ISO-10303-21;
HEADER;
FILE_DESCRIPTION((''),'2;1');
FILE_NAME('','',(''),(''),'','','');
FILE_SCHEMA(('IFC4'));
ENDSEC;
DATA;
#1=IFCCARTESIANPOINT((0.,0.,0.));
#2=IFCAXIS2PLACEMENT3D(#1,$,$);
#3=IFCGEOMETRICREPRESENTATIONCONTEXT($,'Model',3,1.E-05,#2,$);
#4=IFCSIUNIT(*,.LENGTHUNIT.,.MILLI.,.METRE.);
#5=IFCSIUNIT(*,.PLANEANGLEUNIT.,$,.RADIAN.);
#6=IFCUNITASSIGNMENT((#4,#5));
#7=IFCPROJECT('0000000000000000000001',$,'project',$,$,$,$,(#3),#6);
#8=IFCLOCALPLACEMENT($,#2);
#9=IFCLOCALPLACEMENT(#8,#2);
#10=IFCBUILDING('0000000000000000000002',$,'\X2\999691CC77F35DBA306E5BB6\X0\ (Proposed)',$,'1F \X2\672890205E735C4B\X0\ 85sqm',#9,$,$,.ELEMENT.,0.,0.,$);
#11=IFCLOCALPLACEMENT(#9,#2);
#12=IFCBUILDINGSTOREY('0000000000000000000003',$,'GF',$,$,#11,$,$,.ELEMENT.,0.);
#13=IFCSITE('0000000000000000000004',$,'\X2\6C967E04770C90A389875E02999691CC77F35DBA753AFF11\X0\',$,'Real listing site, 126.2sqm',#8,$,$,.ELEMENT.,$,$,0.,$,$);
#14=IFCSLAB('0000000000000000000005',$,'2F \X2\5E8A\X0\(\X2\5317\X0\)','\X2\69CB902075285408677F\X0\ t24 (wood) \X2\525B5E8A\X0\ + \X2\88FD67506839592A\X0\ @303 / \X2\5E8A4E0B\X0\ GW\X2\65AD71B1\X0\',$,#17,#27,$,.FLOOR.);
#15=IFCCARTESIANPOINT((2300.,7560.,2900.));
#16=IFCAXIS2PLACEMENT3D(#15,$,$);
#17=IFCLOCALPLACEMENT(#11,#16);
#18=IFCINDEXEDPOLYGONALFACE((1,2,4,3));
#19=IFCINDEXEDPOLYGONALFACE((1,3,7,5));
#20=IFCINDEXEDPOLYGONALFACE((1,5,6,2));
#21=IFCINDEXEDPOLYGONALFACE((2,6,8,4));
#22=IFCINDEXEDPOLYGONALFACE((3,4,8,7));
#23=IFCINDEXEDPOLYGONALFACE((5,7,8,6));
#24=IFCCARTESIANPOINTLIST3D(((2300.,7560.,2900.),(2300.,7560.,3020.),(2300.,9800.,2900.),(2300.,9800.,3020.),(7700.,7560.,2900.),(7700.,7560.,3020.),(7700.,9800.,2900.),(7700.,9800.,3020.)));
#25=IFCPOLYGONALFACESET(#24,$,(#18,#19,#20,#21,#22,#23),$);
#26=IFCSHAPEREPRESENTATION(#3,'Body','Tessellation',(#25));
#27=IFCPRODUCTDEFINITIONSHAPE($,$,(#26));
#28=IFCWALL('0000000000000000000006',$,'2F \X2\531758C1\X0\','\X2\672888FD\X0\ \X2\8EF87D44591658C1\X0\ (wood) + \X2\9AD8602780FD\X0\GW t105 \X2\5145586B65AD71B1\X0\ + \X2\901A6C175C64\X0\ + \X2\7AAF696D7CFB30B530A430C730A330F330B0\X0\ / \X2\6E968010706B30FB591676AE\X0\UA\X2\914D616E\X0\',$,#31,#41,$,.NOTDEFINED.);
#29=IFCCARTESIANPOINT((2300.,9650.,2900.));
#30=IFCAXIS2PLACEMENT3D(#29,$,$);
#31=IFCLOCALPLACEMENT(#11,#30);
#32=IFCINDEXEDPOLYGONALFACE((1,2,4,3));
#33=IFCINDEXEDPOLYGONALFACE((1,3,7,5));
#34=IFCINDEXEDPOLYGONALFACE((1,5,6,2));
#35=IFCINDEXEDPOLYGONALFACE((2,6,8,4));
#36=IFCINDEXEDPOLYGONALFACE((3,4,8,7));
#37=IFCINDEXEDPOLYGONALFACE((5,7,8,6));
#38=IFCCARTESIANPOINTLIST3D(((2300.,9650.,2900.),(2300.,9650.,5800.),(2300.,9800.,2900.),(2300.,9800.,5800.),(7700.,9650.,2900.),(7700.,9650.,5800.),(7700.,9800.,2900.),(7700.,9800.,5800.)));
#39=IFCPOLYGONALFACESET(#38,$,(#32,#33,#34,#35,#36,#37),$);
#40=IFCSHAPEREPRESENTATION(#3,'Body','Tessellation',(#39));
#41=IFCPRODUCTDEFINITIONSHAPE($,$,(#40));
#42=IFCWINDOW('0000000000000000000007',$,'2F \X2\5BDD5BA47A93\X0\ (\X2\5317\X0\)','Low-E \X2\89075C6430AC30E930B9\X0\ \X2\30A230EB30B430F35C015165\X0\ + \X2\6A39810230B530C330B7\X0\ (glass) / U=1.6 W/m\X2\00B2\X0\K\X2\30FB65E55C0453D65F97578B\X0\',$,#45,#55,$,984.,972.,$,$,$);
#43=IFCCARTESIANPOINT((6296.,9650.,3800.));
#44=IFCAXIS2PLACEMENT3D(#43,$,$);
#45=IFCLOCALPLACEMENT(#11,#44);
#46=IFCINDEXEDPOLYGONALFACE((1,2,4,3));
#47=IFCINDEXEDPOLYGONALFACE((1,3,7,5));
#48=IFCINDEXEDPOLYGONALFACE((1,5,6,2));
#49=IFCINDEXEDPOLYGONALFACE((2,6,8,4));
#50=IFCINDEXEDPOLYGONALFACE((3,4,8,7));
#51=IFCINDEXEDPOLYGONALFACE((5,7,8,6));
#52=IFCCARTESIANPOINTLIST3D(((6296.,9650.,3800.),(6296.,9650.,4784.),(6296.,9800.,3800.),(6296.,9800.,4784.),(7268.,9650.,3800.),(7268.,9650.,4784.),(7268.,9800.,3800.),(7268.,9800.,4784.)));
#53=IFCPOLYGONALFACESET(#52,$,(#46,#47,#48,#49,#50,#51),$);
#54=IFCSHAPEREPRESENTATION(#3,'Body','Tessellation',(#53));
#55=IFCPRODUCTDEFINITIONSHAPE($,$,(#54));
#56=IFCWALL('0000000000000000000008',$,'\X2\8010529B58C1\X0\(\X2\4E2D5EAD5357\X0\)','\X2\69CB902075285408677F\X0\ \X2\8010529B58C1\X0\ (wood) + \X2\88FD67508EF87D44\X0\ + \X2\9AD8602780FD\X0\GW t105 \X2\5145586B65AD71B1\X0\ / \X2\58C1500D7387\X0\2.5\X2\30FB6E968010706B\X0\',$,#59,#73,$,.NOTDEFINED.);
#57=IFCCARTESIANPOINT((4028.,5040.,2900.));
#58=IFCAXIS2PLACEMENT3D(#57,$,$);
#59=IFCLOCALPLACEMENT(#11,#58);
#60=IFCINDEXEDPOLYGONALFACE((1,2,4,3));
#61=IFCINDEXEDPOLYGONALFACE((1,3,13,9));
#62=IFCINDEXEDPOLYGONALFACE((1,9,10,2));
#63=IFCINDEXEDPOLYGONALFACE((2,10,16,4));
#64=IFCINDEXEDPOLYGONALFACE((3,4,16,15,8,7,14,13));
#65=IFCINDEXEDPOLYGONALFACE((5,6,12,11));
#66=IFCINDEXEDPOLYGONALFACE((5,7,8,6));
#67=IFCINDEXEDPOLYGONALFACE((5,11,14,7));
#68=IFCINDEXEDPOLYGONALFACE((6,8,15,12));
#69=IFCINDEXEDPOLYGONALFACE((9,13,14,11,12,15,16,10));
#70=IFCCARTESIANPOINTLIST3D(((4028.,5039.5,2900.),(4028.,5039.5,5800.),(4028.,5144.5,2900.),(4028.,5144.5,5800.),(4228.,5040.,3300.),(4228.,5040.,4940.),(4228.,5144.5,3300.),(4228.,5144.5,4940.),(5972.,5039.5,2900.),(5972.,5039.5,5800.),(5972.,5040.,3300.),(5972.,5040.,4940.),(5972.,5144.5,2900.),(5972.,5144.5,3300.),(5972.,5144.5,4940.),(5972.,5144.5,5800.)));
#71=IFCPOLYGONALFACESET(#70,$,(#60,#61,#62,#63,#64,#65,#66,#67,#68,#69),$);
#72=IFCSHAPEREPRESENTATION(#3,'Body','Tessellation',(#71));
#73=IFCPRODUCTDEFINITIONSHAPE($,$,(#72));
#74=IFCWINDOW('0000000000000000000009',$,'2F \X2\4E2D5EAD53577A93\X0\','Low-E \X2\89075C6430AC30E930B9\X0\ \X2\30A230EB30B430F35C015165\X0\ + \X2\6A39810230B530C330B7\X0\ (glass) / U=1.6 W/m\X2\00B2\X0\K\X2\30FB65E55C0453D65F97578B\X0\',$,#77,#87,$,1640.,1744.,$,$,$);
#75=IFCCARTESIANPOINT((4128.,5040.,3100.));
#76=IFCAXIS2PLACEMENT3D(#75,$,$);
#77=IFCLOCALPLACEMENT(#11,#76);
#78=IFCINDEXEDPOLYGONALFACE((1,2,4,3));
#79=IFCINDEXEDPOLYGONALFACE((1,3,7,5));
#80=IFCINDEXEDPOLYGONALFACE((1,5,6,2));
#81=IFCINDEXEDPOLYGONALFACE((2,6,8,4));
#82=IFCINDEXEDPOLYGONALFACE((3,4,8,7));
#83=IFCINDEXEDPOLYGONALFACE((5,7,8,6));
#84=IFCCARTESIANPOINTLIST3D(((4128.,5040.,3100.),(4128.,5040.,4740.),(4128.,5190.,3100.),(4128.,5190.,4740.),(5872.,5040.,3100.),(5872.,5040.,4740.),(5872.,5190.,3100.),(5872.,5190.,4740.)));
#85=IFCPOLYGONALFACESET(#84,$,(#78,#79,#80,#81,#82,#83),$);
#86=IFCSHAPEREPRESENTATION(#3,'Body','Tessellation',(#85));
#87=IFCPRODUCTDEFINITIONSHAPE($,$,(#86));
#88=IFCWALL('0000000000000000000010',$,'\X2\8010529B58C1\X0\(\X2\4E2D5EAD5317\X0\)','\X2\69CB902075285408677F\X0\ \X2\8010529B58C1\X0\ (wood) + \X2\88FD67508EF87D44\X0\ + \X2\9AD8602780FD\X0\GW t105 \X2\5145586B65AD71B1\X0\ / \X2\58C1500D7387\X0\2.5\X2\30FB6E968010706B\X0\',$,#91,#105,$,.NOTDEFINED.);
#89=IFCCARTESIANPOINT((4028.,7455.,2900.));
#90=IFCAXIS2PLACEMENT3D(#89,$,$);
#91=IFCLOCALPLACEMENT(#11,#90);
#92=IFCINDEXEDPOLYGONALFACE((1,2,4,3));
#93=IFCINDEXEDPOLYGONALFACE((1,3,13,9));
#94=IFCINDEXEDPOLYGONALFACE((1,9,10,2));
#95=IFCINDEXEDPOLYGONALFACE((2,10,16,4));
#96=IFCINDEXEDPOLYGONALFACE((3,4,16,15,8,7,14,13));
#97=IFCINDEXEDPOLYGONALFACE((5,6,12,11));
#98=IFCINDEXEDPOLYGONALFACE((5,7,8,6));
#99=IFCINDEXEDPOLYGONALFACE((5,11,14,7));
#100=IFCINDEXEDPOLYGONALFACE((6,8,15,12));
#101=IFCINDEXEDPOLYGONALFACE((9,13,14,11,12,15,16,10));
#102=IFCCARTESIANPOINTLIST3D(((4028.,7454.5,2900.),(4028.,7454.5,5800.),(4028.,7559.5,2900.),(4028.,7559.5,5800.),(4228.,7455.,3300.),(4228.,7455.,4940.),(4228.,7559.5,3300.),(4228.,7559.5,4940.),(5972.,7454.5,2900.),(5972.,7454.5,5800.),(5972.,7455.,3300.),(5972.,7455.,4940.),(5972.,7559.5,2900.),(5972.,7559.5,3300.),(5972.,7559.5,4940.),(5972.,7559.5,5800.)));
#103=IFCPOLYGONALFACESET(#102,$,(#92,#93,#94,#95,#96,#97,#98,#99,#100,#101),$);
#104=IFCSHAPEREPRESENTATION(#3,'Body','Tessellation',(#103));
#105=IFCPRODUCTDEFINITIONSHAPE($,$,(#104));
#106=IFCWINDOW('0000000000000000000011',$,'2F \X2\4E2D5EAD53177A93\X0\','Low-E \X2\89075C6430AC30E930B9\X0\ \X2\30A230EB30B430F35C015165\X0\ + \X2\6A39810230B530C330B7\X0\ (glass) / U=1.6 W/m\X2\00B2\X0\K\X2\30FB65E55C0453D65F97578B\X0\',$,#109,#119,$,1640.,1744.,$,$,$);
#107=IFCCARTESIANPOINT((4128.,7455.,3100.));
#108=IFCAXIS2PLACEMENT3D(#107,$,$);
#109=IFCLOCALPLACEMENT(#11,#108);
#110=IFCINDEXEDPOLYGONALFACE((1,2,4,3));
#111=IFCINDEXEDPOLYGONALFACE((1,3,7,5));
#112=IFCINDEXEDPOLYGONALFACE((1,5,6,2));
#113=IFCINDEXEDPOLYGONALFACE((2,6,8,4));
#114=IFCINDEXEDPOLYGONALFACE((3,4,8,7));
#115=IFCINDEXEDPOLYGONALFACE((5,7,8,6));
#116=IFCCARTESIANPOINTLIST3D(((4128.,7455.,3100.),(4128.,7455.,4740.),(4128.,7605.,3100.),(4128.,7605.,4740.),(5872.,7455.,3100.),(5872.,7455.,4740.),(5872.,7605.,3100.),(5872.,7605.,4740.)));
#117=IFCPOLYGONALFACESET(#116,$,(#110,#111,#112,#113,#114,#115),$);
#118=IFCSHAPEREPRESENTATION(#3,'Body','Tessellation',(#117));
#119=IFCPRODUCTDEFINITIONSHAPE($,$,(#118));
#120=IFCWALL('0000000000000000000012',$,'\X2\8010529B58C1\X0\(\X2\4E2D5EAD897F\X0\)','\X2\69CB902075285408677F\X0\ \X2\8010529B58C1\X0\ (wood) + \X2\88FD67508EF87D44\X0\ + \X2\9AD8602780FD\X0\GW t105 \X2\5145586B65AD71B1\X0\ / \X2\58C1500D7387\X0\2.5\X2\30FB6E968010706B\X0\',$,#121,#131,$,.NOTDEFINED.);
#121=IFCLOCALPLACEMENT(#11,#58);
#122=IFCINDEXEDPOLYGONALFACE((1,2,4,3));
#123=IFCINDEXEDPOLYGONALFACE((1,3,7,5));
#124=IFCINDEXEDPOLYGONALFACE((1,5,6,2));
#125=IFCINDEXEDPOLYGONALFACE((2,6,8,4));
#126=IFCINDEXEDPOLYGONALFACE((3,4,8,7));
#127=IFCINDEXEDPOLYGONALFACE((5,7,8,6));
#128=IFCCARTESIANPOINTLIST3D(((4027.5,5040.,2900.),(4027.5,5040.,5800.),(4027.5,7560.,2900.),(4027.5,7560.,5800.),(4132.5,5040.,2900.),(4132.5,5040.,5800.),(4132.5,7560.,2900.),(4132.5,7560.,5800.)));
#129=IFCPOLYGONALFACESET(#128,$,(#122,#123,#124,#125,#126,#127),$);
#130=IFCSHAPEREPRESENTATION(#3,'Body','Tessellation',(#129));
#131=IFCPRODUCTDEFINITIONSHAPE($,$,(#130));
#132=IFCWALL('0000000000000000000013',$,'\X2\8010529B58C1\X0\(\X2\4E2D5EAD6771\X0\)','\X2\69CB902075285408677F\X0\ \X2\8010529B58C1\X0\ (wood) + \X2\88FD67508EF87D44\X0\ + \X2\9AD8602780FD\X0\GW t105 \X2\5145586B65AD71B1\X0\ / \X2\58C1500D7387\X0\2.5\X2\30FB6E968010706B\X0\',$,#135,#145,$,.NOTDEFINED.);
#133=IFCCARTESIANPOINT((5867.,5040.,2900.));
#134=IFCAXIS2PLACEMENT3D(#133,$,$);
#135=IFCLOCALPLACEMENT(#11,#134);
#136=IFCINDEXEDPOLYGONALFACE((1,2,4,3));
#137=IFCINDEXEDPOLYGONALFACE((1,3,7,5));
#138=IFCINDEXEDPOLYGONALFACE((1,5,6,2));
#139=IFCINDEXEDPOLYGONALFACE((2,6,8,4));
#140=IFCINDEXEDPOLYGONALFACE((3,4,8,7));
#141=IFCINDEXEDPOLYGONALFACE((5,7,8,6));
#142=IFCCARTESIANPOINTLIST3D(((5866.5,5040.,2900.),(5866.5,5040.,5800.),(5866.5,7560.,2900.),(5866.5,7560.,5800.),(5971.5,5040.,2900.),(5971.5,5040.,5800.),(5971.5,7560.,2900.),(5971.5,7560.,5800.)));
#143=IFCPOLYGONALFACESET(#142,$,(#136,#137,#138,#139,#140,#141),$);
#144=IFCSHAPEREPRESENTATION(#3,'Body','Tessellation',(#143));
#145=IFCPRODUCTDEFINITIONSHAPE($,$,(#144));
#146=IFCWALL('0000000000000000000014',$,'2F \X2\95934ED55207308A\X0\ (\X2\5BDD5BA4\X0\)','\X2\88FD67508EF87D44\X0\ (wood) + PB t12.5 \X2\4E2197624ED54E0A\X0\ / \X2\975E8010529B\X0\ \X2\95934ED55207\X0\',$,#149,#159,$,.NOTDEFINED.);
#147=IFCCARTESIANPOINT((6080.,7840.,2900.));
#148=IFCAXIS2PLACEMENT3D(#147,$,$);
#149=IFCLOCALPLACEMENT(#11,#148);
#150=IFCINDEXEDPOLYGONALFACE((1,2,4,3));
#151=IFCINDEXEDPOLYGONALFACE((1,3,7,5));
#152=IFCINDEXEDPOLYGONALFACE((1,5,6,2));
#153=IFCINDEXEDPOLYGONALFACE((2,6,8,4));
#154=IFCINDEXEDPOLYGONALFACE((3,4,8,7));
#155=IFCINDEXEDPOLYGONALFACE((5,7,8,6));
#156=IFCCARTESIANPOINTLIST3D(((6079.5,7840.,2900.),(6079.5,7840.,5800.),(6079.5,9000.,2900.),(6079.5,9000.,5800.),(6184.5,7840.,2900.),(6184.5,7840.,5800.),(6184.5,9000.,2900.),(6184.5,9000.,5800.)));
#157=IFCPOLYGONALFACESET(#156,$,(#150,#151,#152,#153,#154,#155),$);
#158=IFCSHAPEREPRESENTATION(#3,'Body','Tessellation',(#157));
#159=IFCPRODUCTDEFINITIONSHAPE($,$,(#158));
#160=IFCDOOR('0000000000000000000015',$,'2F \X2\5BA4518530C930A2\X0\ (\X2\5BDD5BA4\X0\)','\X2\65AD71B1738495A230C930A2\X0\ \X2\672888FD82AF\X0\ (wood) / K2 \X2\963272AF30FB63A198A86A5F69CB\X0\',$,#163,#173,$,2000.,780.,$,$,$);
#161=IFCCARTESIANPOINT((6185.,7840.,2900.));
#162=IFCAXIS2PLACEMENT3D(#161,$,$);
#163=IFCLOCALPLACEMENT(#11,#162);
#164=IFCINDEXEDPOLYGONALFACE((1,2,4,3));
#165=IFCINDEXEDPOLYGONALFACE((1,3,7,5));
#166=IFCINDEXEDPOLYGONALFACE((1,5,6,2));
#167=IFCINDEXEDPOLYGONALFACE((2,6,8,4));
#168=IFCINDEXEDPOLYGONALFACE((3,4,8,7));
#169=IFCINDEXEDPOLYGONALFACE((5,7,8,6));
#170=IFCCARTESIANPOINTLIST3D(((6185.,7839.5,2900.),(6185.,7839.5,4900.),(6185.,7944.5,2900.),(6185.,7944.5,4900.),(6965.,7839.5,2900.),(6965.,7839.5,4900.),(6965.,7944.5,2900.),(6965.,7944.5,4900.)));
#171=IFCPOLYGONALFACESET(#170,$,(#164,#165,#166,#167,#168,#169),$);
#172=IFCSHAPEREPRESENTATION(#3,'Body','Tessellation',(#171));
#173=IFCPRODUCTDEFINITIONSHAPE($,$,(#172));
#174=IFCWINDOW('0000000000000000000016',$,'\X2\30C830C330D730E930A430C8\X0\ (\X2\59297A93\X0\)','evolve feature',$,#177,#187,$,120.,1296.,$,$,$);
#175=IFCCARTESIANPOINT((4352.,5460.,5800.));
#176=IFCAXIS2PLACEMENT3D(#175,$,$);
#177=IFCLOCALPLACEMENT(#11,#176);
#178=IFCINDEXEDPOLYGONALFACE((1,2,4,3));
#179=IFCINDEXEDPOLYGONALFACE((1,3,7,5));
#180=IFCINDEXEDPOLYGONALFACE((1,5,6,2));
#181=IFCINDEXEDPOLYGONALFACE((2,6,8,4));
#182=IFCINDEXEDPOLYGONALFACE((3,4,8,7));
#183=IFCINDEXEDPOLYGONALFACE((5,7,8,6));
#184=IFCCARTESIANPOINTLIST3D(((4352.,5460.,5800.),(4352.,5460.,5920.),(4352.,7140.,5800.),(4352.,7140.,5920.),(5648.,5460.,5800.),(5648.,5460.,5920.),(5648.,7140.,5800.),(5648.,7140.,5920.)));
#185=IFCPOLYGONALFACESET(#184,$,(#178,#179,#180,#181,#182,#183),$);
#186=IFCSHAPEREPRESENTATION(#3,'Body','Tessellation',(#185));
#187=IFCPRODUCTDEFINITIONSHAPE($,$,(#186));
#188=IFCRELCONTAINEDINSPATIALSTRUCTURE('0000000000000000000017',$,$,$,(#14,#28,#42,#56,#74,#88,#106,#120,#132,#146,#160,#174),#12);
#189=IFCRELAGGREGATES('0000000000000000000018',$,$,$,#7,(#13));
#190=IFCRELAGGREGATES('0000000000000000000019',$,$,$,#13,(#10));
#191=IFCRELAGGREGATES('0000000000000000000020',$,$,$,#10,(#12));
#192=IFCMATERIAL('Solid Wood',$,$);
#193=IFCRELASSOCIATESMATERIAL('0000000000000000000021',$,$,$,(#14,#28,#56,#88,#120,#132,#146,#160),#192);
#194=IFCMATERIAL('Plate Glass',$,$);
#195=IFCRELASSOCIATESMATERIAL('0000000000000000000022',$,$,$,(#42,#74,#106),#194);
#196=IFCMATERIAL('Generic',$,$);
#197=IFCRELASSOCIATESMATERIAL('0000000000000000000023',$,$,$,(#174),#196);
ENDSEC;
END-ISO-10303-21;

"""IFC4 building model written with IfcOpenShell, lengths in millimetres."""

from ifc_helpers import new_model, si_unit, frame, frame_2d, origin, place, context, project, spatial, rectangle, extrude, material, element, fill, save


model = new_model("IFC4")

# Units and contexts
model_context = context("Model", 3, precision=1e-05, world=origin())
ifc_project = project(units=[si_unit("LENGTHUNIT", "METRE", prefix="MILLI"), si_unit("PLANEANGLEUNIT", "RADIAN")], contexts=[model_context])

# Site, building, storey
site_placement = place(None, origin())
site = spatial("IfcSite", under=ifc_project, at=site_placement, Name="沖縄県那覇市首里石嶺町１", ObjectType="Real listing site, 126.2sqm", CompositionType="ELEMENT", RefElevation=0.0)
building_placement = place(site_placement, origin())
building = spatial("IfcBuilding", under=site, at=building_placement, Name="首里石嶺の家 (Proposed)", ObjectType="1F 木造平屋 85sqm", CompositionType="ELEMENT", ElevationOfRefHeight=0.0, ElevationOfTerrain=0.0)
storey_placement = place(building_placement, origin())
storey = spatial("IfcBuildingStorey", under=building, at=storey_placement, Name="GF", CompositionType="ELEMENT", Elevation=0.0)

# Slab
ifc_material_1 = material(Name="Solid Wood")
slab_placement = place(storey_placement, frame((2300.0, 7560.0, 2900.0)))
element("IfcSlab", 1, at=slab_placement, inside=storey, material=ifc_material_1, Name="2F 床(北)", Description="構造用合板 t24 (wood) 剛床 + 製材根太 @303 / 床下 GW断熱", PredefinedType="FLOOR", context=model_context, shape_type="SweptSolid", body=[
    extrude(rectangle(XDim=5400.0, YDim=2240.0, at=frame_2d((2700.0, 1120.0))), frame((2300.0, 7560.0, 2900.0)), (0.0, 0.0, 1.0), 120.0),
])

# Walls, openings, windows
wall_1_placement = place(storey_placement, frame((2300.0, 9650.0, 2900.0)))
wall_1 = element("IfcWall", 2, at=wall_1_placement, inside=storey, material=ifc_material_1, Name="2F 北壁", Description="木製 軸組外壁 (wood) + 高性能GW t105 充填断熱 + 通気層 + 窯業系サイディング / 準耐火・外皮UA配慮", PredefinedType="NOTDEFINED", context=model_context, shape_type="SweptSolid", body=[
    extrude(rectangle(XDim=5400.0, YDim=150.0, at=frame_2d((2700.0, 75.0))), frame((2300.0, 9650.0, 2900.0)), (0.0, 0.0, 1.0), 2900.0),
])
opening_1_placement = place(storey_placement, frame((6296.0, 9650.0, 3800.0)))
opening_1 = element("IfcOpeningElement", 3, at=opening_1_placement, cuts=wall_1, PredefinedType="NOTDEFINED", context=model_context, shape_type="SweptSolid", body=[
    extrude(rectangle(XDim=972.0, YDim=150.0, at=frame_2d((486.0, 75.0))), frame((6296.0, 9650.0, 3800.0)), (0.0, 0.0, 1.0), 984.0),
])
ifc_material_2 = material(Name="Plate Glass")
window_1_placement = place(storey_placement, frame((6296.0, 9650.0, 3800.0)))
window_1 = element("IfcWindow", 4, at=window_1_placement, inside=storey, material=ifc_material_2, Name="2F 寝室窓 (北)", Description="Low-E 複層ガラス アルゴン封入 + 樹脂サッシ (glass) / U=1.6 W/m²K・日射取得型", OverallHeight=984.0, OverallWidth=972.0, context=model_context, shape_type="SweptSolid", body=[
    extrude(rectangle(XDim=972.0, YDim=150.0, at=frame_2d((486.0, 75.0))), frame((6296.0, 9650.0, 3800.0)), (0.0, 0.0, 1.0), 984.0),
])
fill(opening_1, window_1)
wall_2_placement = place(storey_placement, frame((4028.0, 5040.0, 2900.0)))
wall_2 = element("IfcWall", 5, at=wall_2_placement, inside=storey, material=ifc_material_1, Name="耐力壁(中庭南)", Description="構造用合板 耐力壁 (wood) + 製材軸組 + 高性能GW t105 充填断熱 / 壁倍率2.5・準耐火", PredefinedType="NOTDEFINED", context=model_context, shape_type="SweptSolid", body=[
    extrude(rectangle(XDim=1944.0, YDim=105.0, at=frame_2d((972.0, 52.0))), frame((4028.0, 5040.0, 2900.0)), (0.0, 0.0, 1.0), 2900.0),
])
opening_2_placement = place(storey_placement, frame((4128.0, 5040.0, 3100.0)))
opening_2 = element("IfcOpeningElement", 6, at=opening_2_placement, cuts=wall_2, PredefinedType="NOTDEFINED", context=model_context, shape_type="SweptSolid", body=[
    extrude(rectangle(XDim=1744.0, YDim=150.0, at=frame_2d((872.0, 75.0))), frame((4128.0, 5040.0, 3100.0)), (0.0, 0.0, 1.0), 1640.0),
])
window_2_placement = place(storey_placement, frame((4128.0, 5040.0, 3100.0)))
window_2 = element("IfcWindow", 7, at=window_2_placement, inside=storey, material=ifc_material_2, Name="2F 中庭南窓", Description="Low-E 複層ガラス アルゴン封入 + 樹脂サッシ (glass) / U=1.6 W/m²K・日射取得型", OverallHeight=1640.0, OverallWidth=1744.0, context=model_context, shape_type="SweptSolid", body=[
    extrude(rectangle(XDim=1744.0, YDim=150.0, at=frame_2d((872.0, 75.0))), frame((4128.0, 5040.0, 3100.0)), (0.0, 0.0, 1.0), 1640.0),
])
fill(opening_2, window_2)
wall_3_placement = place(storey_placement, frame((4028.0, 7455.0, 2900.0)))
wall_3 = element("IfcWall", 8, at=wall_3_placement, inside=storey, material=ifc_material_1, Name="耐力壁(中庭北)", Description="構造用合板 耐力壁 (wood) + 製材軸組 + 高性能GW t105 充填断熱 / 壁倍率2.5・準耐火", PredefinedType="NOTDEFINED", context=model_context, shape_type="SweptSolid", body=[
    extrude(rectangle(XDim=1944.0, YDim=105.0, at=frame_2d((972.0, 52.0))), frame((4028.0, 7455.0, 2900.0)), (0.0, 0.0, 1.0), 2900.0),
])
opening_3_placement = place(storey_placement, frame((4128.0, 7455.0, 3100.0)))
opening_3 = element("IfcOpeningElement", 9, at=opening_3_placement, cuts=wall_3, PredefinedType="NOTDEFINED", context=model_context, shape_type="SweptSolid", body=[
    extrude(rectangle(XDim=1744.0, YDim=150.0, at=frame_2d((872.0, 75.0))), frame((4128.0, 7455.0, 3100.0)), (0.0, 0.0, 1.0), 1640.0),
])
window_3_placement = place(storey_placement, frame((4128.0, 7455.0, 3100.0)))
window_3 = element("IfcWindow", 10, at=window_3_placement, inside=storey, material=ifc_material_2, Name="2F 中庭北窓", Description="Low-E 複層ガラス アルゴン封入 + 樹脂サッシ (glass) / U=1.6 W/m²K・日射取得型", OverallHeight=1640.0, OverallWidth=1744.0, context=model_context, shape_type="SweptSolid", body=[
    extrude(rectangle(XDim=1744.0, YDim=150.0, at=frame_2d((872.0, 75.0))), frame((4128.0, 7455.0, 3100.0)), (0.0, 0.0, 1.0), 1640.0),
])
fill(opening_3, window_3)

# Walls
wall_4_placement = place(storey_placement, frame((4028.0, 5040.0, 2900.0)))
element("IfcWall", 11, at=wall_4_placement, inside=storey, material=ifc_material_1, Name="耐力壁(中庭西)", Description="構造用合板 耐力壁 (wood) + 製材軸組 + 高性能GW t105 充填断熱 / 壁倍率2.5・準耐火", PredefinedType="NOTDEFINED", context=model_context, shape_type="SweptSolid", body=[
    extrude(rectangle(XDim=105.0, YDim=2520.0, at=frame_2d((52.0, 1260.0))), frame((4028.0, 5040.0, 2900.0)), (0.0, 0.0, 1.0), 2900.0),
])
wall_5_placement = place(storey_placement, frame((5867.0, 5040.0, 2900.0)))
element("IfcWall", 12, at=wall_5_placement, inside=storey, material=ifc_material_1, Name="耐力壁(中庭東)", Description="構造用合板 耐力壁 (wood) + 製材軸組 + 高性能GW t105 充填断熱 / 壁倍率2.5・準耐火", PredefinedType="NOTDEFINED", context=model_context, shape_type="SweptSolid", body=[
    extrude(rectangle(XDim=105.0, YDim=2520.0, at=frame_2d((52.0, 1260.0))), frame((5867.0, 5040.0, 2900.0)), (0.0, 0.0, 1.0), 2900.0),
])
wall_6_placement = place(storey_placement, frame((6080.0, 7840.0, 2900.0)))
element("IfcWall", 13, at=wall_6_placement, inside=storey, material=ifc_material_1, Name="2F 間仕切り (寝室)", Description="製材軸組 (wood) + PB t12.5 両面仕上 / 非耐力 間仕切", PredefinedType="NOTDEFINED", context=model_context, shape_type="SweptSolid", body=[
    extrude(rectangle(XDim=105.0, YDim=1160.0, at=frame_2d((52.0, 580.0))), frame((6080.0, 7840.0, 2900.0)), (0.0, 0.0, 1.0), 2900.0),
])

# Door
door_placement = place(storey_placement, frame((6185.0, 7840.0, 2900.0)))
element("IfcDoor", 14, at=door_placement, inside=storey, material=ifc_material_1, Name="2F 室内ドア (寝室)", Description="断熱玄関ドア 木製芯 (wood) / K2 防犯・採風機構", OverallHeight=2000.0, OverallWidth=780.0, context=model_context, shape_type="SweptSolid", body=[
    extrude(rectangle(XDim=780.0, YDim=105.0, at=frame_2d((390.0, 52.0))), frame((6185.0, 7840.0, 2900.0)), (0.0, 0.0, 1.0), 2000.0),
])

# Window
ifc_material_3 = material(Name="Generic")
window_4_placement = place(storey_placement, frame((4352.0, 5460.0, 5800.0)))
element("IfcWindow", 15, at=window_4_placement, inside=storey, material=ifc_material_3, Name="トップライト (天窓)", Description="evolve feature", OverallHeight=120.0, OverallWidth=1296.0, context=model_context, shape_type="SweptSolid", body=[
    extrude(rectangle(XDim=1296.0, YDim=1680.0, at=frame_2d((648.0, 840.0))), frame((4352.0, 5460.0, 5800.0)), (0.0, 0.0, 1.0), 120.0),
])

save(model, "model.ifc")
